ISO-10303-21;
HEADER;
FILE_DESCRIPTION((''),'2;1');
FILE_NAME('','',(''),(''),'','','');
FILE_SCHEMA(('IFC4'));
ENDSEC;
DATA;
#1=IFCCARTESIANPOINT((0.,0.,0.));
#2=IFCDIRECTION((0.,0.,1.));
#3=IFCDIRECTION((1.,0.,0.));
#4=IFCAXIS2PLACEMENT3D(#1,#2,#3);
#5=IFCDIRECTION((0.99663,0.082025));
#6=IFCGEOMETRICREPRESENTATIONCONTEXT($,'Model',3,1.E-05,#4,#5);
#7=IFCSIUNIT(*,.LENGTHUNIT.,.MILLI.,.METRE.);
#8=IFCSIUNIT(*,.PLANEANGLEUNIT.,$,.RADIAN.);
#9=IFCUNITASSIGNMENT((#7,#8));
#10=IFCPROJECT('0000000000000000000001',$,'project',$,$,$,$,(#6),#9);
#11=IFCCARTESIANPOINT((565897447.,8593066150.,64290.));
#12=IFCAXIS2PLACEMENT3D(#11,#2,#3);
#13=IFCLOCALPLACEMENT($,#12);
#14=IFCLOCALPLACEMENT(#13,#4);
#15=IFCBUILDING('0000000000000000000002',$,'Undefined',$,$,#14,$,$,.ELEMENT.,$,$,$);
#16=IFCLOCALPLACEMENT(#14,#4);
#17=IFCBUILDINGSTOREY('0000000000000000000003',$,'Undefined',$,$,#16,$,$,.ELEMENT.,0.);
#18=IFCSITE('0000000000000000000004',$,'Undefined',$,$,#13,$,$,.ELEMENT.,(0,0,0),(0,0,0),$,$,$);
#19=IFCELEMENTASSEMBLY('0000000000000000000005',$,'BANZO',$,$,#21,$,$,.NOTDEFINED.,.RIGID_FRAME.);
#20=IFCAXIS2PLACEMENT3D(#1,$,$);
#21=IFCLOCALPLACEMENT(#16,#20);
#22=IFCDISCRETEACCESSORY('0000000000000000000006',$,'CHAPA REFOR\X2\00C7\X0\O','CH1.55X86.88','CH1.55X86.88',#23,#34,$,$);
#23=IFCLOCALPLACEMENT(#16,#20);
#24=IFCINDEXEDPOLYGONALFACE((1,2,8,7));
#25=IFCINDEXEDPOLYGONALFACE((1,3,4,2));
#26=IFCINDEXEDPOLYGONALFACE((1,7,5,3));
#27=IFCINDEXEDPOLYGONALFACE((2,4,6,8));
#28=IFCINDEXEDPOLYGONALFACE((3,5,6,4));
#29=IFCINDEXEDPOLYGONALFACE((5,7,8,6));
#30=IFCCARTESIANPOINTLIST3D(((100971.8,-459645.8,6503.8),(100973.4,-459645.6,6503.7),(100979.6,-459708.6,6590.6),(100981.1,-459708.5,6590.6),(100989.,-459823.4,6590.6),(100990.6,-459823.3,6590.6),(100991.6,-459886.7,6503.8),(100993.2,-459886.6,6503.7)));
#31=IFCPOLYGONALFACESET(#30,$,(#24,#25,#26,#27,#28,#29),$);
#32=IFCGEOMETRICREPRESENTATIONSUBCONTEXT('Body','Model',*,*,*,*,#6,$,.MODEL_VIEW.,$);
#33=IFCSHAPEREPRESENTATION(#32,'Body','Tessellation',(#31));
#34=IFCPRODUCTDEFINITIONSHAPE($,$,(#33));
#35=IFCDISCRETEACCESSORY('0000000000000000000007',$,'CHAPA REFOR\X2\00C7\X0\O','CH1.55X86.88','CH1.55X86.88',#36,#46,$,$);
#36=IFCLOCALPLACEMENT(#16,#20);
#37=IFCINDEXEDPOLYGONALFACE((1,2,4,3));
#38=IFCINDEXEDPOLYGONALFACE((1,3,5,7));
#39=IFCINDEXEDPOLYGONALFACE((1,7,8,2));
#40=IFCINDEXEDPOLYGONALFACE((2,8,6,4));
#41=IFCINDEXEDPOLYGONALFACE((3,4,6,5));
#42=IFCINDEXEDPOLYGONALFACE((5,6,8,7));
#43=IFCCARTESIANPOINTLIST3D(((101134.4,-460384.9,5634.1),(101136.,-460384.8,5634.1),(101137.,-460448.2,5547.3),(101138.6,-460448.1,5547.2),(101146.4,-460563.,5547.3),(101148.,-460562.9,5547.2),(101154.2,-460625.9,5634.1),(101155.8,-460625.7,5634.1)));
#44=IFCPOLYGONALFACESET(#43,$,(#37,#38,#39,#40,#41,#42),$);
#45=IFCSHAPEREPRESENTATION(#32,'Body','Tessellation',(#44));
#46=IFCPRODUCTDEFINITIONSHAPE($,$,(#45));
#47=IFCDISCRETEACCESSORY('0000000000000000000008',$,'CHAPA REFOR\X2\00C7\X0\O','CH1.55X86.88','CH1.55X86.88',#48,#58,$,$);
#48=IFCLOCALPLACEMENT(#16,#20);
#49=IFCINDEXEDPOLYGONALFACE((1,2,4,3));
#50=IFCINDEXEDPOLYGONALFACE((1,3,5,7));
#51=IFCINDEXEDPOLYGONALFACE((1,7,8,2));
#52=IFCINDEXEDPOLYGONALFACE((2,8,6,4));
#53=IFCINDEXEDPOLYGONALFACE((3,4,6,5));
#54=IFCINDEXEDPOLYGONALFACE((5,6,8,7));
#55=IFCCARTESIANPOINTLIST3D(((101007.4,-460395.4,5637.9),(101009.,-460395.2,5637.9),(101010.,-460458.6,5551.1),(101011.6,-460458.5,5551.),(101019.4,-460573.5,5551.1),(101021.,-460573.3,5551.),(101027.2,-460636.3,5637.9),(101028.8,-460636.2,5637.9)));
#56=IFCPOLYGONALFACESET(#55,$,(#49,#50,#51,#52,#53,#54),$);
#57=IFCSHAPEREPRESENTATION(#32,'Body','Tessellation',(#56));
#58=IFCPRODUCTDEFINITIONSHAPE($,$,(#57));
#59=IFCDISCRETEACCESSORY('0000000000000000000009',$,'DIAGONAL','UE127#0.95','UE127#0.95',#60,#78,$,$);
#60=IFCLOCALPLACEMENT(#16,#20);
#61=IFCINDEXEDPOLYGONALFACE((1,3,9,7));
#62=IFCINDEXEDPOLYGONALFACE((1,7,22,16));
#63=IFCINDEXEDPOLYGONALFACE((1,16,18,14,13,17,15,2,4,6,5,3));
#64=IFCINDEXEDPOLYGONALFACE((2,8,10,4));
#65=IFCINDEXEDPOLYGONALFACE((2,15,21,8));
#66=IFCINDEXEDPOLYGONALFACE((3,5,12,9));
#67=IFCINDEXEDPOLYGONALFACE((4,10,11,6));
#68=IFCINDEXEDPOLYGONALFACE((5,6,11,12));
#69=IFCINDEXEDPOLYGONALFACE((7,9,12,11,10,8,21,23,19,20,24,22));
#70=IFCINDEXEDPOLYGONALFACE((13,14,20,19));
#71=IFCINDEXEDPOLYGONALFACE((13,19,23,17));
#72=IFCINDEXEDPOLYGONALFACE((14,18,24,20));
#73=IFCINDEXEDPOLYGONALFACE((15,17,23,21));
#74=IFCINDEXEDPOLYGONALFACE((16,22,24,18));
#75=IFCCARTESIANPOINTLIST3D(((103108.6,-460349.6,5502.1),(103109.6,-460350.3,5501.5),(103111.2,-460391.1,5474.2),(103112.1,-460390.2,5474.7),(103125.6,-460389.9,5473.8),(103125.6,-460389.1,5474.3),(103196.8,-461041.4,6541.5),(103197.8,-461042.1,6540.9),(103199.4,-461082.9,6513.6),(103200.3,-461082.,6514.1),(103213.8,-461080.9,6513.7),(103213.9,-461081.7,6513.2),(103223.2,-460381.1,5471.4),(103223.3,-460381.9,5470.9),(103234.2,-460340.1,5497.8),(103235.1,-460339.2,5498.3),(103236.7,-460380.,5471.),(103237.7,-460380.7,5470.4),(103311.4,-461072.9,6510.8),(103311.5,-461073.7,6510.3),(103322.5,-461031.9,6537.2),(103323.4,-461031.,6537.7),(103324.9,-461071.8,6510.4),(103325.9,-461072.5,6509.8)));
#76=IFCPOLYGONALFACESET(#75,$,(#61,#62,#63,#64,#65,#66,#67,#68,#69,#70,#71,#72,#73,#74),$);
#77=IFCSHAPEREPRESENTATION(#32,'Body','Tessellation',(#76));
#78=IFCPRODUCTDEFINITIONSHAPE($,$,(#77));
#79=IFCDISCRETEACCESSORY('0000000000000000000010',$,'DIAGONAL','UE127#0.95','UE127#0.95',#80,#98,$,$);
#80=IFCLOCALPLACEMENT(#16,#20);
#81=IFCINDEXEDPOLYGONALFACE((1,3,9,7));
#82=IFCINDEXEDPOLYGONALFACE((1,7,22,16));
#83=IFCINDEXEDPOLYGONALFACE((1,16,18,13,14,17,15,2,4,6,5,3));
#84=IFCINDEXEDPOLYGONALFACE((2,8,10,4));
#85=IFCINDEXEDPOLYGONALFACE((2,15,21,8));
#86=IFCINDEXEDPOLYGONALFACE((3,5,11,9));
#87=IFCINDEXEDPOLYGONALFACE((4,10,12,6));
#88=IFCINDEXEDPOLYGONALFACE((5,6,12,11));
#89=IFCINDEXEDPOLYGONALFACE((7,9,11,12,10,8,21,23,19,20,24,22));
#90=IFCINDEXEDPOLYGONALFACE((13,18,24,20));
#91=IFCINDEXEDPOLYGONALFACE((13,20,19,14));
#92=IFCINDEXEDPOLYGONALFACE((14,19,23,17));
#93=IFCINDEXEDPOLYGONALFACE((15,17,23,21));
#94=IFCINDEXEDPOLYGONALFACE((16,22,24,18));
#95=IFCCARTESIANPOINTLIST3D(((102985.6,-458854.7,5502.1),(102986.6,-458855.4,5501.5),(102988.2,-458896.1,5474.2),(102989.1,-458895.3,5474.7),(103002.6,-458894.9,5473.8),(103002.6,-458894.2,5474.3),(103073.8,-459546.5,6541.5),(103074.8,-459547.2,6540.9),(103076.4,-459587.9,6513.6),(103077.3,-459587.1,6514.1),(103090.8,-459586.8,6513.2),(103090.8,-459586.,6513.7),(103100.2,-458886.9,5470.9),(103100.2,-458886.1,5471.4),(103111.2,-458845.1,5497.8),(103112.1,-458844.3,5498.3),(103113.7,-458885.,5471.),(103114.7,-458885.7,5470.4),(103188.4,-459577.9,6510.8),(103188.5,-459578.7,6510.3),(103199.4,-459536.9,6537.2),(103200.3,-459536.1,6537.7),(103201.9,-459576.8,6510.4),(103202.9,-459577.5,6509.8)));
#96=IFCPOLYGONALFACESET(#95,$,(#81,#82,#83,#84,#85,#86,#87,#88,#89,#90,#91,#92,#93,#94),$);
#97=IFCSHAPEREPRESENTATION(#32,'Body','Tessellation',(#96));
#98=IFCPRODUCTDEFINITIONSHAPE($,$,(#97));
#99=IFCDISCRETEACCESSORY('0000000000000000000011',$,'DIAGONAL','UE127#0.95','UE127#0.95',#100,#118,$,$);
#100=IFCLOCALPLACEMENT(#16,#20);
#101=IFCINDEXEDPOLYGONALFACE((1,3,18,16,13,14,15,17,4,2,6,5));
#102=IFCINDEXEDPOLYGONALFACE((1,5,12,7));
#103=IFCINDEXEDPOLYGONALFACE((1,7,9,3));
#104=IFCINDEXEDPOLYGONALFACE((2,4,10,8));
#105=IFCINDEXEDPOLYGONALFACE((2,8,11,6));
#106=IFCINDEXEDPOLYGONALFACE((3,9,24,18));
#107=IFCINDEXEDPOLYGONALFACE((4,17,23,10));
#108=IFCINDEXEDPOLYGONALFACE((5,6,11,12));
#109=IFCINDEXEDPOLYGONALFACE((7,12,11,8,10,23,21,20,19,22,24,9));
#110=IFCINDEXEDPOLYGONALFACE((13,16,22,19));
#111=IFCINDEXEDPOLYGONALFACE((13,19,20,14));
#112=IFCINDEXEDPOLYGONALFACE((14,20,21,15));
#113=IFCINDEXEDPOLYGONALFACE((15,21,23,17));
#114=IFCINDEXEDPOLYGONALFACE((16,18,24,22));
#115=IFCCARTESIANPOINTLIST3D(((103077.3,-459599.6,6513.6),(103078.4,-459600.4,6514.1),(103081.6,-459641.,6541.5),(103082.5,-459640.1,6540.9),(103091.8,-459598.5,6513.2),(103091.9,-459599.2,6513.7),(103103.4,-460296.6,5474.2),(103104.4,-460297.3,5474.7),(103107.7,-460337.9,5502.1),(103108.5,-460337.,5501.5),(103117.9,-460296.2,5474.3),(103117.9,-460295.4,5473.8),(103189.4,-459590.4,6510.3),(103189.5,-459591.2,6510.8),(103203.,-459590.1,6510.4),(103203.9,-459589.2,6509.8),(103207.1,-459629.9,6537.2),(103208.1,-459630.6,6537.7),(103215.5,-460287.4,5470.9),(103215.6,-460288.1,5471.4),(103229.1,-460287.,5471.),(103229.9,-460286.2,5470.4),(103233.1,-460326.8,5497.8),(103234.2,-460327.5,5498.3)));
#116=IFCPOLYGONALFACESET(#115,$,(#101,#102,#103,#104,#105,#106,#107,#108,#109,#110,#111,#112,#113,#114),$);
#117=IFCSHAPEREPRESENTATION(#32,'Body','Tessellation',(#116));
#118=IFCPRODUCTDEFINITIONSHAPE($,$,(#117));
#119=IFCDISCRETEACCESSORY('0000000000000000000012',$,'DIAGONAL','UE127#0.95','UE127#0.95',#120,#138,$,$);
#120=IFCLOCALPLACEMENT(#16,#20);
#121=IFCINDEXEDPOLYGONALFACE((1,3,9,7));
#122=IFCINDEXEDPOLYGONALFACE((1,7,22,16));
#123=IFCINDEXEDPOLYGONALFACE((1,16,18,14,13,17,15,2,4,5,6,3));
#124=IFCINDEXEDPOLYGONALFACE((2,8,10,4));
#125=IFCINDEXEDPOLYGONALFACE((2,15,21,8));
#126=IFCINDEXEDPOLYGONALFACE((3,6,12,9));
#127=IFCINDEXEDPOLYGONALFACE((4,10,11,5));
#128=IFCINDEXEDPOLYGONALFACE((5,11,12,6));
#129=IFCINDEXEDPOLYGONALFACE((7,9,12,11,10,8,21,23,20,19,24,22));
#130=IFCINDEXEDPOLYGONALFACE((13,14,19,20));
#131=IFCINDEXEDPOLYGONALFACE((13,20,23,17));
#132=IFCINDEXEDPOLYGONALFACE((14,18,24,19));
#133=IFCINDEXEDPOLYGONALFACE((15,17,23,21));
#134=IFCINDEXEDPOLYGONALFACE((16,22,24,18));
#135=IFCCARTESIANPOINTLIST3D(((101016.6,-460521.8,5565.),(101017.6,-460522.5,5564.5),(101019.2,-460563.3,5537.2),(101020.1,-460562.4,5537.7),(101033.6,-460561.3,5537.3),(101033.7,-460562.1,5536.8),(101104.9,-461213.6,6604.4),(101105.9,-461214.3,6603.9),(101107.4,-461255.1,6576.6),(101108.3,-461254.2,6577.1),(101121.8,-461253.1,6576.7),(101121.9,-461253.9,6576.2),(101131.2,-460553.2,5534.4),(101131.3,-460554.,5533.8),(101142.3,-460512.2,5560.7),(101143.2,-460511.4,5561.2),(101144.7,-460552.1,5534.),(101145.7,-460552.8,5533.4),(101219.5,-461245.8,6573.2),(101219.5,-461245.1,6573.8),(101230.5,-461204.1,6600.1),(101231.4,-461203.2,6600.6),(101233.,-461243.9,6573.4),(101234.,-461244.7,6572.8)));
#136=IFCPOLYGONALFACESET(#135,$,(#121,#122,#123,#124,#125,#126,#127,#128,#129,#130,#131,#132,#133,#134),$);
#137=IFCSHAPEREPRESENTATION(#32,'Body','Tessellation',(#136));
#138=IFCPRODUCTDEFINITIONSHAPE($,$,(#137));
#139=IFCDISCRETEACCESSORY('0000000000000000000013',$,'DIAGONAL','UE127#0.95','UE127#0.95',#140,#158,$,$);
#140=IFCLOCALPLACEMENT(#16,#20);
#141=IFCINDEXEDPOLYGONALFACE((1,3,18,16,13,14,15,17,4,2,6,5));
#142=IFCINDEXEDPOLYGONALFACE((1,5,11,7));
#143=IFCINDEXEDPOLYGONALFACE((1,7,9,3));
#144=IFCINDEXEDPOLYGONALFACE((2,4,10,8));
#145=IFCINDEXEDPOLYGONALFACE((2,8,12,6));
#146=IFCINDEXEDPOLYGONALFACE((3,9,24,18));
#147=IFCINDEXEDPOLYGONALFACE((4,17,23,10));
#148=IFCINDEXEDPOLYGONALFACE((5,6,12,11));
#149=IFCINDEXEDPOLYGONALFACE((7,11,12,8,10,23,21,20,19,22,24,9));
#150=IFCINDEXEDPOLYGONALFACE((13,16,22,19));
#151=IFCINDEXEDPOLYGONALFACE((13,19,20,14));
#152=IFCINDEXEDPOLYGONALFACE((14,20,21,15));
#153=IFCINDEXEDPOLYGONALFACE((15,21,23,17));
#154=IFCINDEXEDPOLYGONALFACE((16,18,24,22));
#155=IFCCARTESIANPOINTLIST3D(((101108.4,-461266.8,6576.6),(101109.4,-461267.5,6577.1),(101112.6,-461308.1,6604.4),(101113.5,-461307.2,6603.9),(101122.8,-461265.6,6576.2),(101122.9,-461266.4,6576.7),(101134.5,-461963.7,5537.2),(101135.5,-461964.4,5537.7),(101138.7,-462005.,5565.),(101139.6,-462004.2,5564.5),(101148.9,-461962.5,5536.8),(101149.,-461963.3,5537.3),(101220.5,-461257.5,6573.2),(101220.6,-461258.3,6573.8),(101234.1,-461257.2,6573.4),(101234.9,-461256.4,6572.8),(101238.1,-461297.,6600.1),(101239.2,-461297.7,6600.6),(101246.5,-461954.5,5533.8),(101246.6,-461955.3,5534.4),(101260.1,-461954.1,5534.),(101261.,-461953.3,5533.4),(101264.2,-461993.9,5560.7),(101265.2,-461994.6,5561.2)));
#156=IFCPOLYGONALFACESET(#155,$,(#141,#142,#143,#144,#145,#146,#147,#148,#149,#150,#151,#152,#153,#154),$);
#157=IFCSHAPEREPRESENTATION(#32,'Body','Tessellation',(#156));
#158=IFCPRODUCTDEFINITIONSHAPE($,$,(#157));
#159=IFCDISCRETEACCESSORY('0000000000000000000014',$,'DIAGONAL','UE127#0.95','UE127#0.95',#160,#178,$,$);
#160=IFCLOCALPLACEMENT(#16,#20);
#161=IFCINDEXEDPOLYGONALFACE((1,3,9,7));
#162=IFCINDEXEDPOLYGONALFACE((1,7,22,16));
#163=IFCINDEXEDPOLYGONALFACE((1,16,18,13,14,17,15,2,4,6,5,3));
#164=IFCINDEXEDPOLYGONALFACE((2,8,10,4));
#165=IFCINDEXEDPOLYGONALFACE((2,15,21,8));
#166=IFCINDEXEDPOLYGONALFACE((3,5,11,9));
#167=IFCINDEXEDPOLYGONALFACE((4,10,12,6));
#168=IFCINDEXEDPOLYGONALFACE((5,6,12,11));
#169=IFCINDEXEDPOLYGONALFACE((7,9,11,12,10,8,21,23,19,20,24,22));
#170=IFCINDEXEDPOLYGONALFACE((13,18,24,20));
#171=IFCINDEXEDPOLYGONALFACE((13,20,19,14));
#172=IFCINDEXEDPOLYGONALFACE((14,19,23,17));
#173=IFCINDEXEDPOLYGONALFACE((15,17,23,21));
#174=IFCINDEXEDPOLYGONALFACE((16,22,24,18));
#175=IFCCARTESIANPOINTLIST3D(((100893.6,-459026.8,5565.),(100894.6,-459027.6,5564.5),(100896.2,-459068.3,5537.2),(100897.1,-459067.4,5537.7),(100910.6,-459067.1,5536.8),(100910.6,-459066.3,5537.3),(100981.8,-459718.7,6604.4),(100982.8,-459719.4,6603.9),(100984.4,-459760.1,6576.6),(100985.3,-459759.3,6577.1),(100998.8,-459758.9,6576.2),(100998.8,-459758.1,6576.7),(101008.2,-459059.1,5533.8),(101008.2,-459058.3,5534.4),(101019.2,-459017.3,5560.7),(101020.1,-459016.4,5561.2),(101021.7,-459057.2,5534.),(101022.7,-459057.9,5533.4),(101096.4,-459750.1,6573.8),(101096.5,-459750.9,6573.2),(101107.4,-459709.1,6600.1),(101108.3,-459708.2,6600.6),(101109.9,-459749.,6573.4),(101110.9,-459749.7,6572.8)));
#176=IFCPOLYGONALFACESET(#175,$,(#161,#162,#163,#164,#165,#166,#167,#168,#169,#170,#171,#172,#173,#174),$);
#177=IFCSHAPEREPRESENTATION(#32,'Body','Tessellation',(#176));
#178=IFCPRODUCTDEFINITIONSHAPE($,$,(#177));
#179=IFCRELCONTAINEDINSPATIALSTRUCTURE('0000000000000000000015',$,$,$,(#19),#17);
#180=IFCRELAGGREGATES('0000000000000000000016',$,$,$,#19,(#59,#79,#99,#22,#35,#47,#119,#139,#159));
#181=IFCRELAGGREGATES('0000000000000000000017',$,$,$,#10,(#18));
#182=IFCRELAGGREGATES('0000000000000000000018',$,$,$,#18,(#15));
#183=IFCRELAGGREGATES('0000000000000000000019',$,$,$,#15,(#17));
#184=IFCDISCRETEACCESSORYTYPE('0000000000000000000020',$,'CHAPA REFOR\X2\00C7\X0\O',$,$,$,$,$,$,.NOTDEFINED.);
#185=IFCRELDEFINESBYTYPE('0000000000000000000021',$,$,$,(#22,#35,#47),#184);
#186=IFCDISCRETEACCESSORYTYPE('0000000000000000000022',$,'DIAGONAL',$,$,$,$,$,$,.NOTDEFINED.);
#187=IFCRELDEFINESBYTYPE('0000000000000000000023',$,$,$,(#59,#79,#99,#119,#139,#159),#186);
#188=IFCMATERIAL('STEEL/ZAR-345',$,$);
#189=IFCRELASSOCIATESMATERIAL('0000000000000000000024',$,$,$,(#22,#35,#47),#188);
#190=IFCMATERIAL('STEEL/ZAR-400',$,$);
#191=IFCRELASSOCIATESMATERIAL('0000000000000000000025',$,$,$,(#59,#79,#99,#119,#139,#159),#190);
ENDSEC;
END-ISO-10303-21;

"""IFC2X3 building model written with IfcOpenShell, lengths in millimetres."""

from ifc_helpers import new_model, si_unit, direction, frame, frame_2d, origin_with_axes, place, context, subcontext, project, spatial, polyline, c_section, outline, extrude, material, type_object, element, aggregate, save


model = new_model("IFC2X3")

# Units and contexts
model_context = context("Model", 3, precision=1e-05, world=origin_with_axes(), true_north=direction((0.99663, 0.082025)))
body_context = subcontext(model_context, "Body", "Model", "MODEL_VIEW")
ifc_project = project(units=[si_unit("LENGTHUNIT", "METRE", prefix="MILLI"), si_unit("PLANEANGLEUNIT", "RADIAN")], contexts=[model_context])

# Site, building, storey
site_placement = place(None, frame((565897447.0, 8593066150.0, 64290.0), z_axis=(0.0, 0.0, 1.0), x_axis=(1.0, 0.0, 0.0)))
site = spatial("IfcSite", under=ifc_project, at=site_placement, Name="Undefined", CompositionType="ELEMENT", RefLatitude=(0, 0, 0), RefLongitude=(0, 0, 0))
building_placement = place(site_placement, origin_with_axes())
building = spatial("IfcBuilding", under=site, at=building_placement, Name="Undefined", CompositionType="ELEMENT")
storey_placement = place(building_placement, origin_with_axes())
storey = spatial("IfcBuildingStorey", under=building, at=storey_placement, Name="Undefined", CompositionType="ELEMENT", Elevation=0.0)

# Shared definitions
ifc_material_1 = material(Name="STEEL/ZAR-400")

# Element assembly, discrete accessories
assembly_1_placement = place(storey_placement, origin_with_axes())
assembly_1 = element("IfcElementAssembly", 1, at=assembly_1_placement, inside=storey, Name="BANZO", AssemblyPlace="NOTDEFINED", PredefinedType="RIGID_FRAME")
ifc_material_2 = material(Name="STEEL/ZAR-345")
discrete_accessory_type_1 = type_object("IfcDiscreteAccessoryType", Name="CHAPA REFORÇO")
discrete_accessory_1_placement = place(assembly_1_placement, frame((100992.4, -459886.6, 6503.8), z_axis=(0.996182, 0.081989, -0.029987), x_axis=(-0.082025, 0.99663, 0.0)))
discrete_accessory_1 = element("IfcDiscreteAccessory", 2, at=discrete_accessory_1_placement, type_object=discrete_accessory_type_1, material=ifc_material_2, Name="CHAPA REFORÇO", Description="CH1.55X86.88", ObjectType="CH1.55X86.88", context=body_context, shape_type="SweptSolid", body=[
    extrude(outline(polyline([(0.0, 0.0), (241.7, 0.0), (178.5, 86.9), (63.3, 86.9), (0.0, 0.0)])), frame((0.0, 0.0, -0.8), z_axis=(0.0, 0.0, 1.0), x_axis=(1.0, 0.0, 0.0)), (0.0, 0.0, 1.0), 1.6),
])
discrete_accessory_2_placement = place(assembly_1_placement, frame((101135.2, -460384.9, 5634.1), z_axis=(0.996182, 0.081989, -0.029987), x_axis=(0.082025, -0.99663, 0.0)))
discrete_accessory_2 = element("IfcDiscreteAccessory", 3, at=discrete_accessory_2_placement, type_object=discrete_accessory_type_1, material=ifc_material_2, Name="CHAPA REFORÇO", Description="CH1.55X86.88", ObjectType="CH1.55X86.88", context=body_context, shape_type="SweptSolid", body=[
    extrude(outline(polyline([(0.0, 0.0), (241.7, 0.0), (178.5, 86.9), (63.3, 86.9), (0.0, 0.0)])), frame((0.0, 0.0, -0.8), z_axis=(0.0, 0.0, 1.0), x_axis=(1.0, 0.0, 0.0)), (0.0, 0.0, 1.0), 1.6),
])
discrete_accessory_3_placement = place(assembly_1_placement, frame((101008.2, -460395.3, 5637.9), z_axis=(0.996182, 0.081989, -0.029987), x_axis=(0.082025, -0.99663, 0.0)))
discrete_accessory_3 = element("IfcDiscreteAccessory", 4, at=discrete_accessory_3_placement, type_object=discrete_accessory_type_1, material=ifc_material_2, Name="CHAPA REFORÇO", Description="CH1.55X86.88", ObjectType="CH1.55X86.88", context=body_context, shape_type="SweptSolid", body=[
    extrude(outline(polyline([(0.0, 0.0), (241.7, 0.0), (178.5, 86.9), (63.3, 86.9), (0.0, 0.0)])), frame((0.0, 0.0, -0.8), z_axis=(0.0, 0.0, 1.0), x_axis=(1.0, 0.0, 0.0)), (0.0, 0.0, 1.0), 1.6),
])
discrete_accessory_type_2 = type_object("IfcDiscreteAccessoryType", Name="DIAGONAL")
discrete_accessory_4_placement = place(assembly_1_placement, frame((103173.2, -460365.1, 5486.2), z_axis=(-0.996182, -0.081989, 0.029987), x_axis=(0.070485, -0.552697, 0.830396)))
discrete_accessory_4 = element("IfcDiscreteAccessory", 5, at=discrete_accessory_4_placement, type_object=discrete_accessory_type_2, material=ifc_material_1, Name="DIAGONAL", Description="UE127#0.95", ObjectType="UE127#0.95", context=body_context, shape_type="SweptSolid", body=[
    extrude(c_section(Depth=127.0, Width=50.0, WallThickness=0.9, Girth=14.5, at=frame_2d((0.0, 0.0), x_axis=(1.0, 0.0))), frame((1251.7, 0.0, 0.0), z_axis=(-1.0, 0.0, 0.0), x_axis=(0.0, -1.0, 0.0)), (0.0, 0.0, 1.0), 1251.7),
])
discrete_accessory_5_placement = place(assembly_1_placement, frame((103050.1, -458870.2, 5486.2), z_axis=(-0.996182, -0.081989, 0.029987), x_axis=(0.070485, -0.552697, 0.830396)))
discrete_accessory_5 = element("IfcDiscreteAccessory", 6, at=discrete_accessory_5_placement, type_object=discrete_accessory_type_2, material=ifc_material_1, Name="DIAGONAL", Description="UE127#0.95", ObjectType="UE127#0.95", context=body_context, shape_type="SweptSolid", body=[
    extrude(c_section(Depth=127.0, Width=50.0, WallThickness=0.9, Girth=14.5, at=frame_2d((0.0, 0.0), x_axis=(1.0, 0.0))), frame((1251.7, 0.0, 0.0), z_axis=(-1.0, 0.0, 0.0), x_axis=(0.0, -1.0, 0.0)), (0.0, 0.0, 1.0), 1251.7),
])
discrete_accessory_6_placement = place(assembly_1_placement, frame((103142.7, -459615.1, 6525.7), z_axis=(-0.996182, -0.081989, 0.029987), x_axis=(0.020829, -0.556784, -0.830396)))
discrete_accessory_6 = element("IfcDiscreteAccessory", 7, at=discrete_accessory_6_placement, type_object=discrete_accessory_type_2, material=ifc_material_1, Name="DIAGONAL", Description="UE127#0.95", ObjectType="UE127#0.95", context=body_context, shape_type="SweptSolid", body=[
    extrude(c_section(Depth=127.0, Width=50.0, WallThickness=0.9, Girth=14.5, at=frame_2d((0.0, 0.0), x_axis=(1.0, 0.0))), frame((1251.7, 0.0, 0.0), z_axis=(-1.0, 0.0, 0.0), x_axis=(0.0, -1.0, 0.0)), (0.0, 0.0, 1.0), 1251.7),
])
discrete_accessory_7_placement = place(assembly_1_placement, frame((101081.2, -460537.3, 5549.2), z_axis=(-0.996182, -0.081989, 0.029987), x_axis=(0.070485, -0.552697, 0.830396)))
discrete_accessory_7 = element("IfcDiscreteAccessory", 8, at=discrete_accessory_7_placement, type_object=discrete_accessory_type_2, material=ifc_material_1, Name="DIAGONAL", Description="UE127#0.95", ObjectType="UE127#0.95", context=body_context, shape_type="SweptSolid", body=[
    extrude(c_section(Depth=127.0, Width=50.0, WallThickness=0.9, Girth=14.5, at=frame_2d((0.0, 0.0), x_axis=(1.0, 0.0))), frame((1251.7, 0.0, 0.0), z_axis=(-1.0, 0.0, 0.0), x_axis=(0.0, -1.0, 0.0)), (0.0, 0.0, 1.0), 1251.7),
])
discrete_accessory_8_placement = place(assembly_1_placement, frame((101173.8, -461282.2, 6588.6), z_axis=(-0.996182, -0.081989, 0.029987), x_axis=(0.020829, -0.556784, -0.830396)))
discrete_accessory_8 = element("IfcDiscreteAccessory", 9, at=discrete_accessory_8_placement, type_object=discrete_accessory_type_2, material=ifc_material_1, Name="DIAGONAL", Description="UE127#0.95", ObjectType="UE127#0.95", context=body_context, shape_type="SweptSolid", body=[
    extrude(c_section(Depth=127.0, Width=50.0, WallThickness=0.9, Girth=14.5, at=frame_2d((0.0, 0.0), x_axis=(1.0, 0.0))), frame((1251.7, 0.0, 0.0), z_axis=(-1.0, 0.0, 0.0), x_axis=(0.0, -1.0, 0.0)), (0.0, 0.0, 1.0), 1251.7),
])
discrete_accessory_9_placement = place(assembly_1_placement, frame((100958.1, -459042.4, 5549.2), z_axis=(-0.996182, -0.081989, 0.029987), x_axis=(0.070485, -0.552697, 0.830396)))
discrete_accessory_9 = element("IfcDiscreteAccessory", 10, at=discrete_accessory_9_placement, type_object=discrete_accessory_type_2, material=ifc_material_1, Name="DIAGONAL", Description="UE127#0.95", ObjectType="UE127#0.95", context=body_context, shape_type="SweptSolid", body=[
    extrude(c_section(Depth=127.0, Width=50.0, WallThickness=0.9, Girth=14.5, at=frame_2d((0.0, 0.0), x_axis=(1.0, 0.0))), frame((1251.7, 0.0, 0.0), z_axis=(-1.0, 0.0, 0.0), x_axis=(0.0, -1.0, 0.0)), (0.0, 0.0, 1.0), 1251.7),
])
aggregate(assembly_1, [discrete_accessory_4, discrete_accessory_5, discrete_accessory_6, discrete_accessory_1, discrete_accessory_2, discrete_accessory_3, discrete_accessory_7, discrete_accessory_8, discrete_accessory_9])

save(model, "model.ifc")
